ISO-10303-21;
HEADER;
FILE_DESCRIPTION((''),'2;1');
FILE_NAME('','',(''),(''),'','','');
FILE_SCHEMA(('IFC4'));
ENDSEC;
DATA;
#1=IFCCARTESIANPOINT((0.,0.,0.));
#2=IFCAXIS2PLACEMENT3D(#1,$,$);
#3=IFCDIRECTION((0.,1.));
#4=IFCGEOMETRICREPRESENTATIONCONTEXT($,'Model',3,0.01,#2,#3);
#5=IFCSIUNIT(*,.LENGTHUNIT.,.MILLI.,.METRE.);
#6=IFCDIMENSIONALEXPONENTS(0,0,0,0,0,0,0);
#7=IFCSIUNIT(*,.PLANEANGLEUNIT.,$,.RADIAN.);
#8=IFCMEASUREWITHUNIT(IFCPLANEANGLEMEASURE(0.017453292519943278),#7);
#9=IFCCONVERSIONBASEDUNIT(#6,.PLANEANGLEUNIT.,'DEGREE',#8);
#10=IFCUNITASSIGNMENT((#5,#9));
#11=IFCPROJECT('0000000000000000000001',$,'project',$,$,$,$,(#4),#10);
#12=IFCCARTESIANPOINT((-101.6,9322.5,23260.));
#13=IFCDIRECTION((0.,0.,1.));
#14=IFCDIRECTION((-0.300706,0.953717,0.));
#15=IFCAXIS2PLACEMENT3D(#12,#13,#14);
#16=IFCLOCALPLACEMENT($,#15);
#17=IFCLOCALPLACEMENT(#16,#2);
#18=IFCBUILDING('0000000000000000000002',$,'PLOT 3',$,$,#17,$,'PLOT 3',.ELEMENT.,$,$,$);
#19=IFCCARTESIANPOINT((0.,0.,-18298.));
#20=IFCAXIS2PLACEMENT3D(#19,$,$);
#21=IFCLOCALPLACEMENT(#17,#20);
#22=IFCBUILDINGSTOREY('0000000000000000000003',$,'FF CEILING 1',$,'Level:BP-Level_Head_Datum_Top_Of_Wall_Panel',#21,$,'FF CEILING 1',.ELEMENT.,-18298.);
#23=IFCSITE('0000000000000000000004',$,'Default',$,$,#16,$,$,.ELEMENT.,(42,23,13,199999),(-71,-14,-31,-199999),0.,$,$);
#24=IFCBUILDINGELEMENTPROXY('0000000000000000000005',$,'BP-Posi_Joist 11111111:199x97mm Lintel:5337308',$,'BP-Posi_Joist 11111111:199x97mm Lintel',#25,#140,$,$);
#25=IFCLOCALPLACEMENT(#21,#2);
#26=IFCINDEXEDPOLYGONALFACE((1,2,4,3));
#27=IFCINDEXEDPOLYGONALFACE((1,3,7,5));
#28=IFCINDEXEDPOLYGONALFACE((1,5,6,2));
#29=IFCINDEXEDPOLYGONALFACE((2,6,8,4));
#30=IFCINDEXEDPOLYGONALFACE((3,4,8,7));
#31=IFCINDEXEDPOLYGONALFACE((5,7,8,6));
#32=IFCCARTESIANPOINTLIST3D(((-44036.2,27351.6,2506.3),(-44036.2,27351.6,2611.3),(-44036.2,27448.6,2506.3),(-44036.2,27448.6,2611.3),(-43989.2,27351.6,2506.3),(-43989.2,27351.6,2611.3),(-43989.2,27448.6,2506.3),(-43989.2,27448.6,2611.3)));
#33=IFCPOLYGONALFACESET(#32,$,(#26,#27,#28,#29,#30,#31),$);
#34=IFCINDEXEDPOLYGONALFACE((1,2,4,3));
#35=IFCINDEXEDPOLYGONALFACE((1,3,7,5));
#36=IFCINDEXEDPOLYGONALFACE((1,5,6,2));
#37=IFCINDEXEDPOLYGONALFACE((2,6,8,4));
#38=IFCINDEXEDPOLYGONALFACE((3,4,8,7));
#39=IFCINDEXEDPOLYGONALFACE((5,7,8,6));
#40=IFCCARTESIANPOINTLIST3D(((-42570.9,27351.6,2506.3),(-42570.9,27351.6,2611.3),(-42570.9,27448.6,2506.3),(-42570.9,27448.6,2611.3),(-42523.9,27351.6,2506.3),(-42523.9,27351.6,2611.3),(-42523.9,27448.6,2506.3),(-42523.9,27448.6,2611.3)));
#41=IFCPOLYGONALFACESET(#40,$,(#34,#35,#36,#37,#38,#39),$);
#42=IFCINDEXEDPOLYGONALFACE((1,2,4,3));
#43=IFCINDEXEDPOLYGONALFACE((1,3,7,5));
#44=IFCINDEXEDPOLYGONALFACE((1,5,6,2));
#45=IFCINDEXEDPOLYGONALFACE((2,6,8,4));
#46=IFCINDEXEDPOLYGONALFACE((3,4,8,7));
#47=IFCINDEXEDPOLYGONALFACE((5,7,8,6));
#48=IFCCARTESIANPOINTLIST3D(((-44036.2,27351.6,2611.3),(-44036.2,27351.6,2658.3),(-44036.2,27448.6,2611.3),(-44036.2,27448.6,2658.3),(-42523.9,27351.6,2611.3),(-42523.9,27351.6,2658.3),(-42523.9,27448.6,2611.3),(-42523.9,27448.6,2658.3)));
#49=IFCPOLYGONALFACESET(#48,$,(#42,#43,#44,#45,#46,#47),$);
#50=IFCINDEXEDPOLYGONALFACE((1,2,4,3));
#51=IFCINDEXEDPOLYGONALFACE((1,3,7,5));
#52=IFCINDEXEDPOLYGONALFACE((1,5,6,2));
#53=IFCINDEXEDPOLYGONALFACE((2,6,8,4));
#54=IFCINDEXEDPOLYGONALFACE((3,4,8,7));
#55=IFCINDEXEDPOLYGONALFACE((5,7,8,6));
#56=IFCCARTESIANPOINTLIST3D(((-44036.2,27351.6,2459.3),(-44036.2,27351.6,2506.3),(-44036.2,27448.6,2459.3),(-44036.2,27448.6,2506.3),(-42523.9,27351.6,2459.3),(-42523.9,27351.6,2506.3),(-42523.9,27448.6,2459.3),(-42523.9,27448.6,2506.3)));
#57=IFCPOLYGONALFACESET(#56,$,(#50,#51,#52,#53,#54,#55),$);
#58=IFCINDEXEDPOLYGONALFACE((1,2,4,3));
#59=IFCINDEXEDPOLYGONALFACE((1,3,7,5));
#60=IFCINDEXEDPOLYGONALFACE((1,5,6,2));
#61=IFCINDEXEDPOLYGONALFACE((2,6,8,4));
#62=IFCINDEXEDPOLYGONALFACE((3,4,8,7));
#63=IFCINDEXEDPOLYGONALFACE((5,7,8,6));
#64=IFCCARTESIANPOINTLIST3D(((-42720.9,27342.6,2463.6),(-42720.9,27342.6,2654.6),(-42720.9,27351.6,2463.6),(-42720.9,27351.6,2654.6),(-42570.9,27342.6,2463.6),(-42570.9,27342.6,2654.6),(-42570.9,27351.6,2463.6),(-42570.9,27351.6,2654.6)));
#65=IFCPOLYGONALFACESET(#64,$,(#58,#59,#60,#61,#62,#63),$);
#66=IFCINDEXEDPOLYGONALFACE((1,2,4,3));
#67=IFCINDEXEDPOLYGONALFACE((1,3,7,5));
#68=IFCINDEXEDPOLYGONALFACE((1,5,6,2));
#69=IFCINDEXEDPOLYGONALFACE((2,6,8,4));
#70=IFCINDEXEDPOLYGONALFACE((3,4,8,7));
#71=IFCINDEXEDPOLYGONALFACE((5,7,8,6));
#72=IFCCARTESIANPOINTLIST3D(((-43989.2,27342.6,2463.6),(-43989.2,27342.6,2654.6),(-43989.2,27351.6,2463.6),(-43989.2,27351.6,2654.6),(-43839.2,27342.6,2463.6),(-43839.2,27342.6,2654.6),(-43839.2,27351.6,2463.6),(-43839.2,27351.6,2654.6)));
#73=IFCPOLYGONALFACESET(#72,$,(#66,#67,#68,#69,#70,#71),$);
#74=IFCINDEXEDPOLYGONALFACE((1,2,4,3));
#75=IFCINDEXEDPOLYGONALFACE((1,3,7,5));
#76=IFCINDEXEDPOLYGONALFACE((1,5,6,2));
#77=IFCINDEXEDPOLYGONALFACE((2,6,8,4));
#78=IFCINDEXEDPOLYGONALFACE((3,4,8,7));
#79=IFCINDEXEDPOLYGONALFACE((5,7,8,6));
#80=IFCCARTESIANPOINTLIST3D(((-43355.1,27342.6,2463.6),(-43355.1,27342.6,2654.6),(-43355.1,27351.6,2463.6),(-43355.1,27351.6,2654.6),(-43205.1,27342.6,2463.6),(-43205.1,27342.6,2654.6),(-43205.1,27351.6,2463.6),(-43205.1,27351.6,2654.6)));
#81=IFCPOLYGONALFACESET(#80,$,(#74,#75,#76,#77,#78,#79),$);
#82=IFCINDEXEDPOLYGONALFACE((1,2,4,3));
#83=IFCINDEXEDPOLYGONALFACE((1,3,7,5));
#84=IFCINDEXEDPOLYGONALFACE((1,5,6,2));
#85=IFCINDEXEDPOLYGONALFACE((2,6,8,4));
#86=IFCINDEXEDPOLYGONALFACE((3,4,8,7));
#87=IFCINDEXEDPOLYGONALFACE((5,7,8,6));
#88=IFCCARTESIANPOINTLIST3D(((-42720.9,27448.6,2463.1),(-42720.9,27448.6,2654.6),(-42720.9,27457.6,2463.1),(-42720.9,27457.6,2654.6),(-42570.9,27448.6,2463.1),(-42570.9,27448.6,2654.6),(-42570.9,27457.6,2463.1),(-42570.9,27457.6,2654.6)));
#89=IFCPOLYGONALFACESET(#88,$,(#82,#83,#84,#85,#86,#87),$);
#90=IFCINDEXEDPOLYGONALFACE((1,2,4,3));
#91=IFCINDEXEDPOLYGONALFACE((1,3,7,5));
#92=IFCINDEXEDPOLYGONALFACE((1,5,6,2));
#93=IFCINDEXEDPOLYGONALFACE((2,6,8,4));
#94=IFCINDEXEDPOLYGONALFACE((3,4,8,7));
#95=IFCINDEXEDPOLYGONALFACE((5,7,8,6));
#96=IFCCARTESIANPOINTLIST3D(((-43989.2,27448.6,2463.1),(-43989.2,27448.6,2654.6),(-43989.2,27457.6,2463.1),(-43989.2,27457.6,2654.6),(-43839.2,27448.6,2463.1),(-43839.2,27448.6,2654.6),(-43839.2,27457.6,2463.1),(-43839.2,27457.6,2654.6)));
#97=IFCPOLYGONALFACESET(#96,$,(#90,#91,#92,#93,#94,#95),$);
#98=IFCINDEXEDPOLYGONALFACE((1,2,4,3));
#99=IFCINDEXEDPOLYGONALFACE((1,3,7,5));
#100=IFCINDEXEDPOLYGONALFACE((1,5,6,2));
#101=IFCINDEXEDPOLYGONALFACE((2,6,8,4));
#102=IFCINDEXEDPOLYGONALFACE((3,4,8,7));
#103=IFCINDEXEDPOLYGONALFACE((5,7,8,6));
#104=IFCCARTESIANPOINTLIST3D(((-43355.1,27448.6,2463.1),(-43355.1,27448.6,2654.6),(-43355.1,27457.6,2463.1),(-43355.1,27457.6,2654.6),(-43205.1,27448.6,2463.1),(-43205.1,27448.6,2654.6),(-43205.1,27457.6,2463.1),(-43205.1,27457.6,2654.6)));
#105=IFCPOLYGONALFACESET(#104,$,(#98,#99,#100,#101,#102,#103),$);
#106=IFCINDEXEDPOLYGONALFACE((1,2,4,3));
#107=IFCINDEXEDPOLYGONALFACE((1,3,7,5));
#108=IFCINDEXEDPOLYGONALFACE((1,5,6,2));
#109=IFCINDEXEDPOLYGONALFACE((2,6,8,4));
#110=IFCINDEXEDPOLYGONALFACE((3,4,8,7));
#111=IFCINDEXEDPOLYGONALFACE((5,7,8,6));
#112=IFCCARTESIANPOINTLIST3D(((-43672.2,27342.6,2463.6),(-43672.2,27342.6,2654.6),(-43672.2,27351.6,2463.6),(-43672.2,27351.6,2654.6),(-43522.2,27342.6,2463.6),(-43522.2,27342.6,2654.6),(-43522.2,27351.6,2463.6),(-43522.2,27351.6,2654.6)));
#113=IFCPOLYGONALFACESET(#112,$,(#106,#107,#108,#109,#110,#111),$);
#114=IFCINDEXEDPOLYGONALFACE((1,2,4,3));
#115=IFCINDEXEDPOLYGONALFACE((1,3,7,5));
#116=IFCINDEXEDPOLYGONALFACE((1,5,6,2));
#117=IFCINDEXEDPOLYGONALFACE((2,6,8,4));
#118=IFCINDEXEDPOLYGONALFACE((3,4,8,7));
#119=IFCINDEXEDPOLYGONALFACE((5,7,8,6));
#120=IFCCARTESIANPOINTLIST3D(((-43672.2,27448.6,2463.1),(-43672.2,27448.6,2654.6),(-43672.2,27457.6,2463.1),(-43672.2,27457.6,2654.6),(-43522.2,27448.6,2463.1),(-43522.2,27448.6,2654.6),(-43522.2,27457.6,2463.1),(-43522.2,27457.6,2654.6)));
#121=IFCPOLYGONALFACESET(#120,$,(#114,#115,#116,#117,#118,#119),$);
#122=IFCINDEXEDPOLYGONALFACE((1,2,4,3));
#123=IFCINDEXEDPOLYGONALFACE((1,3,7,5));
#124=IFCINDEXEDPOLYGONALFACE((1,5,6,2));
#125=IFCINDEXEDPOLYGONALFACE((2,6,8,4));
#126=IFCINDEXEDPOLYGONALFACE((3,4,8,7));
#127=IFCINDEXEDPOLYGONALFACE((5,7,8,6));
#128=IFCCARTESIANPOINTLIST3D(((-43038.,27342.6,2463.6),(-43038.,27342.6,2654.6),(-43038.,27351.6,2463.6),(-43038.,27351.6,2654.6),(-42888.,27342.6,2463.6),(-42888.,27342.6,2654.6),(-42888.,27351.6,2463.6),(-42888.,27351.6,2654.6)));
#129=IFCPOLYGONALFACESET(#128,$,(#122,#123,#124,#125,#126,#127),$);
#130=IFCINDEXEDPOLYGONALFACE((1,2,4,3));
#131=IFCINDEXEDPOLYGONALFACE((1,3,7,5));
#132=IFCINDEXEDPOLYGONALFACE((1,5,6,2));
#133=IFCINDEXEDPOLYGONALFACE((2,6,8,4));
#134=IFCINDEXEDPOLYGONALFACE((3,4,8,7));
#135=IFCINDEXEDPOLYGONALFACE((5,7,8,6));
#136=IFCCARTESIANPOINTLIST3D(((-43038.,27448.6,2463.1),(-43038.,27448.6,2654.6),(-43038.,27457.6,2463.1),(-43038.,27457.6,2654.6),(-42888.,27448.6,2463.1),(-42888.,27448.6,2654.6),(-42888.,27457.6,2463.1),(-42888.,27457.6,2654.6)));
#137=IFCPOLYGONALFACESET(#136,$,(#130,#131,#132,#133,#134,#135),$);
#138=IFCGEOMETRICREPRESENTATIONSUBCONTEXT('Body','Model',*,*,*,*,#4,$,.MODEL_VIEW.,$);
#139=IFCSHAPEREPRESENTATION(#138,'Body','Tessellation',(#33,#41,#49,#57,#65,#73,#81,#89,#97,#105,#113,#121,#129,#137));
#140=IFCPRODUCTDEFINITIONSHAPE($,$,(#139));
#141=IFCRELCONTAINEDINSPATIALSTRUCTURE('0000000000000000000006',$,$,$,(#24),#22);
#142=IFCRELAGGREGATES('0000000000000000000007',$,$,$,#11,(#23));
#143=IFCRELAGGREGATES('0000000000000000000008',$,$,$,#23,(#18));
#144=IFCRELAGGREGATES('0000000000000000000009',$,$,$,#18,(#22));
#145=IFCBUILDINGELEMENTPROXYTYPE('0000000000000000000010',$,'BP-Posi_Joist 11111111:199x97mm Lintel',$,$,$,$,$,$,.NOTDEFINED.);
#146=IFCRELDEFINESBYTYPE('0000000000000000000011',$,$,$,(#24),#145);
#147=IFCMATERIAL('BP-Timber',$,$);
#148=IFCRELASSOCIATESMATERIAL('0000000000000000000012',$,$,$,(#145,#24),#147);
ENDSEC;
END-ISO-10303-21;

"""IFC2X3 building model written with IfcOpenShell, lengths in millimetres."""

from ifc_helpers import new_model, entity, si_unit, converted_unit, direction, frame, frame_2d, origin, origin_2d_with_axis, place, context, subcontext, project, spatial, rectangle, extrude, source, transform, mapped, material, type_object, type_shapes, element, save


model = new_model("IFC2X3")

# Units and contexts
model_context = context("Model", 3, precision=0.01, world=origin(), true_north=direction((0.0, 1.0)))
body_context = subcontext(model_context, "Body", "Model", "MODEL_VIEW")
ifc_project = project(units=[si_unit("LENGTHUNIT", "METRE", prefix="MILLI"), converted_unit("PLANEANGLEUNIT", "DEGREE", entity("IfcPlaneAngleMeasure", 0.017453292519943278), si_unit("PLANEANGLEUNIT", "RADIAN"), dimensions=[0, 0, 0, 0, 0, 0, 0])], contexts=[model_context])

# Site, building, storey
site_placement = place(None, frame((-101.6, 9322.5, 23260.0), z_axis=(0.0, 0.0, 1.0), x_axis=(-0.300706, 0.953717, 0.0)))
site = spatial("IfcSite", under=ifc_project, at=site_placement, Name="Default", CompositionType="ELEMENT", RefLatitude=(42, 23, 13, 199999), RefLongitude=(-71, -14, -31, -199999), RefElevation=0.0)
building_placement = place(site_placement, origin())
building = spatial("IfcBuilding", under=site, at=building_placement, Name="PLOT 3", LongName="PLOT 3", CompositionType="ELEMENT")
storey_placement = place(building_placement, frame((0.0, 0.0, -18298.0)))
storey = spatial("IfcBuildingStorey", under=building, at=storey_placement, Name="FF CEILING 1", ObjectType="Level:BP-Level_Head_Datum_Top_Of_Wall_Panel", LongName="FF CEILING 1", CompositionType="ELEMENT", Elevation=-18298.0)

# Building element proxy
ifc_material_1 = material(Name="BP-Timber")
building_element_proxy_type_1 = type_object("IfcBuildingElementProxyType", Name="BP-Posi_Joist 11111111:199x97mm Lintel", PredefinedType="NOTDEFINED", material=ifc_material_1)
shared_shape_1 = source(origin(), body_context, "Body", "SweptSolid", [
    extrude(rectangle(XDim=97.0, YDim=47.0, at=origin_2d_with_axis()), frame((320.4, 0.0, -152.0), z_axis=(0.0, 0.0, 1.0), x_axis=(0.0, 1.0, 0.0)), (0.0, 0.0, 1.0), 105.0),
    extrude(rectangle(XDim=97.0, YDim=47.0, at=frame_2d((0.0, 0.0), x_axis=(1.0, 0.0))), frame((1785.7, 0.0, -152.0), z_axis=(0.0, 0.0, 1.0), x_axis=(0.0, 1.0, 0.0)), (0.0, 0.0, 1.0), 105.0),
    extrude(rectangle(XDim=1512.3, YDim=97.0, at=frame_2d((0.0, 0.0), x_axis=(1.0, 0.0))), frame((1053.1, 0.0, -47.0)), (0.0, 0.0, 1.0), 47.0),
    extrude(rectangle(XDim=1512.3, YDim=97.0, at=frame_2d((0.0, 0.0), x_axis=(1.0, 0.0))), frame((1053.1, 0.0, -199.0)), (0.0, 0.0, 1.0), 47.0),
    extrude(rectangle(XDim=150.0, YDim=9.0, at=frame_2d((0.0, 0.0), x_axis=(1.0, 0.0))), frame((1687.2, -53.0, -194.8)), (0.0, 0.0, 1.0), 191.0),
    extrude(rectangle(XDim=150.0, YDim=9.0, at=frame_2d((0.0, 0.0), x_axis=(1.0, 0.0))), frame((418.9, -53.0, -194.7), z_axis=(0.0, 0.0, 1.0), x_axis=(-1.0, 0.0, 0.0)), (0.0, 0.0, 1.0), 191.0),
    extrude(rectangle(XDim=150.0, YDim=9.0, at=frame_2d((0.0, 0.0), x_axis=(1.0, 0.0))), frame((1053.1, -53.0, -194.8)), (0.0, 0.0, 1.0), 191.0),
    extrude(rectangle(XDim=150.0, YDim=9.0, at=origin_2d_with_axis()), frame((1687.2, 53.0, -195.3)), (0.0, 0.0, 1.0), 191.5),
    extrude(rectangle(XDim=150.0, YDim=9.0, at=frame_2d((0.0, 0.0), x_axis=(1.0, 0.0))), frame((418.9, 53.0, -195.3), z_axis=(0.0, 0.0, 1.0), x_axis=(-1.0, 0.0, 0.0)), (0.0, 0.0, 1.0), 191.5),
    extrude(rectangle(XDim=150.0, YDim=9.0, at=origin_2d_with_axis()), frame((1053.1, 53.0, -195.3)), (0.0, 0.0, 1.0), 191.5),
    extrude(rectangle(XDim=150.0, YDim=9.0, at=frame_2d((0.0, 0.0), x_axis=(1.0, 0.0))), frame((736.0, -53.0, -194.7), z_axis=(0.0, 0.0, 1.0), x_axis=(-1.0, 0.0, 0.0)), (0.0, 0.0, 1.0), 191.0),
    extrude(rectangle(XDim=150.0, YDim=9.0, at=frame_2d((0.0, 0.0), x_axis=(1.0, 0.0))), frame((736.0, 53.0, -195.3), z_axis=(0.0, 0.0, 1.0), x_axis=(-1.0, 0.0, 0.0)), (0.0, 0.0, 1.0), 191.5),
    extrude(rectangle(XDim=150.0, YDim=9.0, at=origin_2d_with_axis()), frame((1370.1, -53.0, -194.8)), (0.0, 0.0, 1.0), 191.0),
    extrude(rectangle(XDim=150.0, YDim=9.0, at=origin_2d_with_axis()), frame((1370.1, 53.0, -195.3)), (0.0, 0.0, 1.0), 191.5),
])
type_shapes(building_element_proxy_type_1, [shared_shape_1])
proxy_1_placement = place(storey_placement, frame((-44333.1, 27400.1, 2658.3)))
element("IfcBuildingElementProxy", 1, at=proxy_1_placement, inside=storey, type_object=building_element_proxy_type_1, material=ifc_material_1, Name="BP-Posi_Joist 11111111:199x97mm Lintel:5337308", ObjectType="BP-Posi_Joist 11111111:199x97mm Lintel", context=body_context, shape_type="MappedRepresentation", body=[
    mapped(shared_shape_1, transform((0.0, 0.0, 0.0), scale=1.0)),
])

save(model, "model.ifc")
